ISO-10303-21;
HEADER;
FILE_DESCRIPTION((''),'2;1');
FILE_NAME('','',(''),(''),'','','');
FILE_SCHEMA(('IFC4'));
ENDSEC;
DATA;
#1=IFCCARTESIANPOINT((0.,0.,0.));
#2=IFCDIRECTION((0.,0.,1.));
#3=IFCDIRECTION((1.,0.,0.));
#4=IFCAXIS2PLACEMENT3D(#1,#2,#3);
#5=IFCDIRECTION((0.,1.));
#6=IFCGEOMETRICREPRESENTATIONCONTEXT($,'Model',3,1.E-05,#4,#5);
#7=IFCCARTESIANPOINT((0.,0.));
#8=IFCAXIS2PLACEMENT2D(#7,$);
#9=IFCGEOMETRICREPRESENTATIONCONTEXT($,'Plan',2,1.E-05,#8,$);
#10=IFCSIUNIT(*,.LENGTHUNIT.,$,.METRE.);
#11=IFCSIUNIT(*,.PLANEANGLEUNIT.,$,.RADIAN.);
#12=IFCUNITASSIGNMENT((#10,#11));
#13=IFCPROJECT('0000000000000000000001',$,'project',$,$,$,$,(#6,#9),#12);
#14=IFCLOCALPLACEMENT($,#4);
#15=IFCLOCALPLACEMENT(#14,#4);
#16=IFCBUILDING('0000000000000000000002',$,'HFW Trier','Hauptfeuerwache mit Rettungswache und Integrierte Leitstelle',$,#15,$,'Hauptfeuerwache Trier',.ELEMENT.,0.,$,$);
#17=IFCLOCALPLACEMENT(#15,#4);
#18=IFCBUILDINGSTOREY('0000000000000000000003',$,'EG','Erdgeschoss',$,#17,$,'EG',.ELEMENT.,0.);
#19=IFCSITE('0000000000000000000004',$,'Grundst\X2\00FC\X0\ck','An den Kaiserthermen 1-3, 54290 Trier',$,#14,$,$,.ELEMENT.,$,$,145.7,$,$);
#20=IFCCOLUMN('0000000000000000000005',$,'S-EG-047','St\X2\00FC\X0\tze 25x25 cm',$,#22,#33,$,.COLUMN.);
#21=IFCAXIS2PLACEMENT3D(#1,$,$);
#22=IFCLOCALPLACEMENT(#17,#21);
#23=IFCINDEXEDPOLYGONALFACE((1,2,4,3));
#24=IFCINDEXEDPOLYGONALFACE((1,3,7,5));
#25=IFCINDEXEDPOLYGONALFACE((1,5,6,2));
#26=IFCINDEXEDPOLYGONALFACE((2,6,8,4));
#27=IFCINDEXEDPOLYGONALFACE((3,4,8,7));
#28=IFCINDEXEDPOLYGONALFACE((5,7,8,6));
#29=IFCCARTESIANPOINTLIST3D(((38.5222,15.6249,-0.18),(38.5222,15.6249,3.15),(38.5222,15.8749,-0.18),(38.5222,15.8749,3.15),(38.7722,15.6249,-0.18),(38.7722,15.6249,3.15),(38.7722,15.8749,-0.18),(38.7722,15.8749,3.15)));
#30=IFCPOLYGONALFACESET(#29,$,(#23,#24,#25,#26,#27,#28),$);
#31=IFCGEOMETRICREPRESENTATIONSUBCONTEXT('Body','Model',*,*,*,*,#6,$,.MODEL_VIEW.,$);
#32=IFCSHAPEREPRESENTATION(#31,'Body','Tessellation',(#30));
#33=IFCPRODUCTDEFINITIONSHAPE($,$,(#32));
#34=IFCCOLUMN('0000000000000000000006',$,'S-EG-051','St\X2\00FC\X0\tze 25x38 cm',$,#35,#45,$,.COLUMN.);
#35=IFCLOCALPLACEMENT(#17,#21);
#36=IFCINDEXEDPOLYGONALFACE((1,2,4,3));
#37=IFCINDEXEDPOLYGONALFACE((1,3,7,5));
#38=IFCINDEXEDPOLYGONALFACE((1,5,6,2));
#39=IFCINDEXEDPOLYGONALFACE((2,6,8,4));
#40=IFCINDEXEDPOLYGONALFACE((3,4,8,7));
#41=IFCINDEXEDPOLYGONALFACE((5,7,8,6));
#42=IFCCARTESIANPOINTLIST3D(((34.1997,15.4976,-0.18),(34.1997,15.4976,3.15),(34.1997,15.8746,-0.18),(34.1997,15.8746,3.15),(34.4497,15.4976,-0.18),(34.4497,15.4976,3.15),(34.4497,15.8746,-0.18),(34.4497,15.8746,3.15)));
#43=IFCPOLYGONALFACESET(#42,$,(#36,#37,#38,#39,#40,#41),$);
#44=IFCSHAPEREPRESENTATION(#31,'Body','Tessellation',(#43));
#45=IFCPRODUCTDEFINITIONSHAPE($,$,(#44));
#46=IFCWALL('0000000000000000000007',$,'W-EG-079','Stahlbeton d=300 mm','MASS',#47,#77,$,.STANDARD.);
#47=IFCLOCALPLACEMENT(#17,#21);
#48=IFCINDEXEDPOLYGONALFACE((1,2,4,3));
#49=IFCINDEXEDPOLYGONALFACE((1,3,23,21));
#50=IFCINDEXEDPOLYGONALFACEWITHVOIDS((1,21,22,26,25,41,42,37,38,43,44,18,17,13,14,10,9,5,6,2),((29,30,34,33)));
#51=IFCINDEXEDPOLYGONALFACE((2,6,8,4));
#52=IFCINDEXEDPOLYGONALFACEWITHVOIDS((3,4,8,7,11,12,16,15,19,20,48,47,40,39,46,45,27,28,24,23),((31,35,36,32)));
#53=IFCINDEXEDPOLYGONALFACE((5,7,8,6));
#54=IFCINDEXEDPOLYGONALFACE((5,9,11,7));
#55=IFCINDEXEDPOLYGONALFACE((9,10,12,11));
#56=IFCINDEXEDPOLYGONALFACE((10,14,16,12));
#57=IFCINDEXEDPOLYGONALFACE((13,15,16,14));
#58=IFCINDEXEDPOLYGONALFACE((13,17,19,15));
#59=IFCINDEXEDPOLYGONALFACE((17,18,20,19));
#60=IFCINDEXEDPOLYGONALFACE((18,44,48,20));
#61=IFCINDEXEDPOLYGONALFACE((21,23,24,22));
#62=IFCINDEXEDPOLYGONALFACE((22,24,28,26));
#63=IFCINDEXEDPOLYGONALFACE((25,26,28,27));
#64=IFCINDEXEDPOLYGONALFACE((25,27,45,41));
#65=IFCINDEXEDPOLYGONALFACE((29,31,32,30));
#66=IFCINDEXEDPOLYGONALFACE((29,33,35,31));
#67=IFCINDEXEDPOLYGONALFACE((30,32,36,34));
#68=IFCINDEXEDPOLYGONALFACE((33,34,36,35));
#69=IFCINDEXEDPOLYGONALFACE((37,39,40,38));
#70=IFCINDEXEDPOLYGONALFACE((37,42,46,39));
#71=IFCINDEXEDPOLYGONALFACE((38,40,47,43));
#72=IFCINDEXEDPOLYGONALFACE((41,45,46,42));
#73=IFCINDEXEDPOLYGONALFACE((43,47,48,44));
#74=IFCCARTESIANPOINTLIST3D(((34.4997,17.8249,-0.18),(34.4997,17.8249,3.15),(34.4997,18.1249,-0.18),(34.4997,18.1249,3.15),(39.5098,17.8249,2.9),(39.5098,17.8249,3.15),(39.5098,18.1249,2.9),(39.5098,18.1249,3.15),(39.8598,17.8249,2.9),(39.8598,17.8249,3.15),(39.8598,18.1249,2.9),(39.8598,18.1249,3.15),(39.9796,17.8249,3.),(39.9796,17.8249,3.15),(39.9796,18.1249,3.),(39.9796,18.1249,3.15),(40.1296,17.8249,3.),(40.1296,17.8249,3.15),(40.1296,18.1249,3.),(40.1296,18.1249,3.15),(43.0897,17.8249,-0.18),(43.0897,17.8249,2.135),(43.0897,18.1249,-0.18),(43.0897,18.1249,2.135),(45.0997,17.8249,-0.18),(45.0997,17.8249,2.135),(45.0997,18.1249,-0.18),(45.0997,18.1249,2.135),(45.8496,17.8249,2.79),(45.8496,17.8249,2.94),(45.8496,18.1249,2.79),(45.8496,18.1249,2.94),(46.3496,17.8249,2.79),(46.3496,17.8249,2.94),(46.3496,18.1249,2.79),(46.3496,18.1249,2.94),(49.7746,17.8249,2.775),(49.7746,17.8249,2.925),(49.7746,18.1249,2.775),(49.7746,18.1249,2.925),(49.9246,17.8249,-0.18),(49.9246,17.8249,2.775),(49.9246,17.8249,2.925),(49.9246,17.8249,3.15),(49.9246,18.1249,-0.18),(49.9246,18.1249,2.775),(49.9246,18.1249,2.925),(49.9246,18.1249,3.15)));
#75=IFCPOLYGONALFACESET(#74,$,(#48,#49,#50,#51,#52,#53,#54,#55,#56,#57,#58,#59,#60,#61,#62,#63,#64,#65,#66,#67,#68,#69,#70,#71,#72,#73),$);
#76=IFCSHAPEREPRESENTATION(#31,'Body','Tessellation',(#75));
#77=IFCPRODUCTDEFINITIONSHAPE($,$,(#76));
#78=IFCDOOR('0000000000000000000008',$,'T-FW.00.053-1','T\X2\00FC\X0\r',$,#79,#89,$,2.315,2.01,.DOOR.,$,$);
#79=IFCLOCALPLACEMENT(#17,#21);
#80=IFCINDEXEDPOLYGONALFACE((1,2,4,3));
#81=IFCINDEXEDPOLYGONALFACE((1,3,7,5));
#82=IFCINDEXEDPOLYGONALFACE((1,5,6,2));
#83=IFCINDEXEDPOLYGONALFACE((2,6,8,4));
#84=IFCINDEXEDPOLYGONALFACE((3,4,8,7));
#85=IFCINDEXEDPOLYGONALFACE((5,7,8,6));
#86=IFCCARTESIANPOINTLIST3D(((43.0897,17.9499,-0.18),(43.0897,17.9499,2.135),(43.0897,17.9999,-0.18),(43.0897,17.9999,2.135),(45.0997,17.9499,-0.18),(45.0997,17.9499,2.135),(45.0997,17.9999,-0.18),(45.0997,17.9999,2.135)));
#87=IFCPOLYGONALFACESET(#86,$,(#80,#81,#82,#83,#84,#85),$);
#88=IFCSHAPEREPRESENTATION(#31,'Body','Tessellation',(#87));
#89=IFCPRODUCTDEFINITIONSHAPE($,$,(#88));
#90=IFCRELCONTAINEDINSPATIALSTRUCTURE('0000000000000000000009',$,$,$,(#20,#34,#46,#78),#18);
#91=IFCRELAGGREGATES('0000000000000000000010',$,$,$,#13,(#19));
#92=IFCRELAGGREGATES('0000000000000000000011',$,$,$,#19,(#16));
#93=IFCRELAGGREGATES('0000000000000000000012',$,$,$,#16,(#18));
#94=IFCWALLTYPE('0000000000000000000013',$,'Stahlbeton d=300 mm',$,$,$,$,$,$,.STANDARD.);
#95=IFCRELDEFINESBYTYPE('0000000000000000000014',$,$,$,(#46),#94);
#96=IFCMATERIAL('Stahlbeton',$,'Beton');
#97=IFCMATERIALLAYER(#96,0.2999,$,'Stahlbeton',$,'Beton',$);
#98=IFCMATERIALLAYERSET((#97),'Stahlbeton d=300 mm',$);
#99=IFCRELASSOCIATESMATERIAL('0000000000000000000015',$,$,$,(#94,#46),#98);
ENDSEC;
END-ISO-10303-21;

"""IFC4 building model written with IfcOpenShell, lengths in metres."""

from ifc_helpers import new_model, si_unit, direction, frame, frame_2d, origin_with_axes, origin_2d, place, context, subcontext, project, spatial, rectangle, extrude, material, layer, layer_set, layer_usage, type_object, element, fill, save


model = new_model("IFC4")

# Units and contexts
model_context = context("Model", 3, precision=1e-05, world=origin_with_axes(), true_north=direction((0.0, 1.0)))
plan_context = context("Plan", 2, precision=1e-05, world=origin_2d())
body_context = subcontext(model_context, "Body", "Model", "MODEL_VIEW")
ifc_project = project(units=[si_unit("LENGTHUNIT", "METRE"), si_unit("PLANEANGLEUNIT", "RADIAN")], contexts=[model_context, plan_context])

# Site, building, storey
site_placement = place(None, origin_with_axes())
site = spatial("IfcSite", under=ifc_project, at=site_placement, Name="Grundstück", Description="An den Kaiserthermen 1-3, 54290 Trier", CompositionType="ELEMENT", RefElevation=145.7)
building_placement = place(site_placement, origin_with_axes())
building = spatial("IfcBuilding", under=site, at=building_placement, Name="HFW Trier", Description="Hauptfeuerwache mit Rettungswache und Integrierte Leitstelle", LongName="Hauptfeuerwache Trier", CompositionType="ELEMENT", ElevationOfRefHeight=0.0)
storey_placement = place(building_placement, origin_with_axes())
storey = spatial("IfcBuildingStorey", under=building, at=storey_placement, Name="EG", Description="Erdgeschoss", LongName="EG", CompositionType="ELEMENT", Elevation=0.0)

# Columns
column_1_placement = place(storey_placement, frame((38.5222, 15.7499, -0.18), z_axis=(0.0, 0.0, 1.0), x_axis=(1.0, 0.0, 0.0)))
element("IfcColumn", 1, at=column_1_placement, inside=storey, Name="S-EG-047", Description="Stütze 25x25 cm", PredefinedType="COLUMN", context=body_context, shape_type="SweptSolid", body=[
    extrude(rectangle(XDim=0.25, YDim=0.25, at=frame_2d((0.125, 0.0))), origin_with_axes(), (0.0, 0.0, 1.0), 3.33),
])
column_2_placement = place(storey_placement, frame((34.1997, 15.6861, -0.18), z_axis=(0.0, 0.0, 1.0), x_axis=(1.0, 0.0, 0.0)))
element("IfcColumn", 2, at=column_2_placement, inside=storey, Name="S-EG-051", Description="Stütze 25x38 cm", PredefinedType="COLUMN", context=body_context, shape_type="SweptSolid", body=[
    extrude(rectangle(XDim=0.25, YDim=0.377, at=frame_2d((0.125, 0.0))), origin_with_axes(), (0.0, 0.0, 1.0), 3.33),
])

# Wall, openings, door
ifc_material = material(Name="Stahlbeton", Category="Beton")
ifc_layer_1 = layer(ifc_material, 0.2999, Name="Stahlbeton", Category="Beton")
ifc_layer_set_1 = layer_set([ifc_layer_1], Name="Stahlbeton d=300 mm")
ifc_layer_usage_1 = layer_usage(ifc_layer_set_1, "AXIS2", "POSITIVE", -0.15)
wall_type_1 = type_object("IfcWallType", Name="Stahlbeton d=300 mm", PredefinedType="STANDARD", material=ifc_layer_set_1)
wall_1_placement = place(storey_placement, frame((34.4997, 17.9749, -0.18), z_axis=(0.0, 0.0, 1.0), x_axis=(1.0, 0.0, 0.0)))
wall_1 = element("IfcWall", 3, at=wall_1_placement, inside=storey, type_object=wall_type_1, material=ifc_layer_usage_1, Name="W-EG-079", Description="Stahlbeton d=300 mm", ObjectType="MASS", PredefinedType="STANDARD", context=body_context, shape_type="SweptSolid", body=[
    extrude(rectangle(XDim=15.4249, YDim=0.3, at=frame_2d((7.7125, 0.0))), origin_with_axes(), (0.0, 0.0, 1.0), 3.33),
])
opening_1_placement = place(wall_1_placement, frame((8.59, 0.0, 0.0), z_axis=(0.0, 0.0, 1.0), x_axis=(1.0, 0.0, 0.0)))
opening_1 = element("IfcOpeningElement", 4, at=opening_1_placement, cuts=wall_1, PredefinedType="OPENING", context=body_context, shape_type="SweptSolid", body=[
    extrude(rectangle(XDim=2.01, YDim=0.4, at=frame_2d((1.005, 0.0))), origin_with_axes(), (0.0, 0.0, 1.0), 2.315),
])
opening_2_placement = place(wall_1_placement, origin_with_axes())
element("IfcOpeningElement", 5, at=opening_2_placement, cuts=wall_1, ObjectType="Wanddurchbruch", PredefinedType="OPENING", context=body_context, shape_type="SweptSolid", body=[
    extrude(rectangle(XDim=0.5, YDim=0.4, at=frame_2d((11.5999, 0.0))), frame((0.0, 0.0, 2.97), z_axis=(0.0, 0.0, 1.0), x_axis=(1.0, 0.0, 0.0)), (0.0, 0.0, 1.0), 0.15),
])
opening_3_placement = place(wall_1_placement, origin_with_axes())
element("IfcOpeningElement", 6, at=opening_3_placement, cuts=wall_1, ObjectType="Wanddurchbruch", PredefinedType="OPENING", context=body_context, shape_type="SweptSolid", body=[
    extrude(rectangle(XDim=0.15, YDim=0.4, at=frame_2d((5.5549, 0.0))), frame((0.0, 0.0, 3.18), z_axis=(0.0, 0.0, 1.0), x_axis=(1.0, 0.0, 0.0)), (0.0, 0.0, 1.0), 0.15),
])
opening_4_placement = place(wall_1_placement, origin_with_axes())
element("IfcOpeningElement", 7, at=opening_4_placement, cuts=wall_1, ObjectType="Wanddurchbruch", PredefinedType="OPENING", context=body_context, shape_type="SweptSolid", body=[
    extrude(rectangle(XDim=0.35, YDim=0.4, at=frame_2d((5.1851, 0.0))), frame((0.0, 0.0, 3.08), z_axis=(0.0, 0.0, 1.0), x_axis=(1.0, 0.0, 0.0)), (0.0, 0.0, 1.0), 0.25),
])
opening_5_placement = place(wall_1_placement, origin_with_axes())
element("IfcOpeningElement", 8, at=opening_5_placement, cuts=wall_1, ObjectType="Wanddurchbruch", PredefinedType="OPENING", context=body_context, shape_type="SweptSolid", body=[
    extrude(rectangle(XDim=0.15, YDim=0.4, at=frame_2d((15.3499, 0.0))), frame((0.0, 0.0, 2.955), z_axis=(0.0, 0.0, 1.0), x_axis=(1.0, 0.0, 0.0)), (0.0, 0.0, 1.0), 0.15),
])
door_1_placement = place(wall_1_placement, frame((8.59, 0.0, 0.0), z_axis=(0.0, 0.0, 1.0), x_axis=(1.0, 0.0, 0.0)))
door_1 = element("IfcDoor", 9, at=door_1_placement, inside=storey, Name="T-FW.00.053-1", Description="Tür", OverallHeight=2.315, OverallWidth=2.01, PredefinedType="DOOR", context=body_context, shape_type="SweptSolid", body=[
    extrude(rectangle(XDim=2.01, YDim=0.05, at=frame_2d((1.005, 0.0))), origin_with_axes(), (0.0, 0.0, 1.0), 2.315),
])
fill(opening_1, door_1)

save(model, "model.ifc")
